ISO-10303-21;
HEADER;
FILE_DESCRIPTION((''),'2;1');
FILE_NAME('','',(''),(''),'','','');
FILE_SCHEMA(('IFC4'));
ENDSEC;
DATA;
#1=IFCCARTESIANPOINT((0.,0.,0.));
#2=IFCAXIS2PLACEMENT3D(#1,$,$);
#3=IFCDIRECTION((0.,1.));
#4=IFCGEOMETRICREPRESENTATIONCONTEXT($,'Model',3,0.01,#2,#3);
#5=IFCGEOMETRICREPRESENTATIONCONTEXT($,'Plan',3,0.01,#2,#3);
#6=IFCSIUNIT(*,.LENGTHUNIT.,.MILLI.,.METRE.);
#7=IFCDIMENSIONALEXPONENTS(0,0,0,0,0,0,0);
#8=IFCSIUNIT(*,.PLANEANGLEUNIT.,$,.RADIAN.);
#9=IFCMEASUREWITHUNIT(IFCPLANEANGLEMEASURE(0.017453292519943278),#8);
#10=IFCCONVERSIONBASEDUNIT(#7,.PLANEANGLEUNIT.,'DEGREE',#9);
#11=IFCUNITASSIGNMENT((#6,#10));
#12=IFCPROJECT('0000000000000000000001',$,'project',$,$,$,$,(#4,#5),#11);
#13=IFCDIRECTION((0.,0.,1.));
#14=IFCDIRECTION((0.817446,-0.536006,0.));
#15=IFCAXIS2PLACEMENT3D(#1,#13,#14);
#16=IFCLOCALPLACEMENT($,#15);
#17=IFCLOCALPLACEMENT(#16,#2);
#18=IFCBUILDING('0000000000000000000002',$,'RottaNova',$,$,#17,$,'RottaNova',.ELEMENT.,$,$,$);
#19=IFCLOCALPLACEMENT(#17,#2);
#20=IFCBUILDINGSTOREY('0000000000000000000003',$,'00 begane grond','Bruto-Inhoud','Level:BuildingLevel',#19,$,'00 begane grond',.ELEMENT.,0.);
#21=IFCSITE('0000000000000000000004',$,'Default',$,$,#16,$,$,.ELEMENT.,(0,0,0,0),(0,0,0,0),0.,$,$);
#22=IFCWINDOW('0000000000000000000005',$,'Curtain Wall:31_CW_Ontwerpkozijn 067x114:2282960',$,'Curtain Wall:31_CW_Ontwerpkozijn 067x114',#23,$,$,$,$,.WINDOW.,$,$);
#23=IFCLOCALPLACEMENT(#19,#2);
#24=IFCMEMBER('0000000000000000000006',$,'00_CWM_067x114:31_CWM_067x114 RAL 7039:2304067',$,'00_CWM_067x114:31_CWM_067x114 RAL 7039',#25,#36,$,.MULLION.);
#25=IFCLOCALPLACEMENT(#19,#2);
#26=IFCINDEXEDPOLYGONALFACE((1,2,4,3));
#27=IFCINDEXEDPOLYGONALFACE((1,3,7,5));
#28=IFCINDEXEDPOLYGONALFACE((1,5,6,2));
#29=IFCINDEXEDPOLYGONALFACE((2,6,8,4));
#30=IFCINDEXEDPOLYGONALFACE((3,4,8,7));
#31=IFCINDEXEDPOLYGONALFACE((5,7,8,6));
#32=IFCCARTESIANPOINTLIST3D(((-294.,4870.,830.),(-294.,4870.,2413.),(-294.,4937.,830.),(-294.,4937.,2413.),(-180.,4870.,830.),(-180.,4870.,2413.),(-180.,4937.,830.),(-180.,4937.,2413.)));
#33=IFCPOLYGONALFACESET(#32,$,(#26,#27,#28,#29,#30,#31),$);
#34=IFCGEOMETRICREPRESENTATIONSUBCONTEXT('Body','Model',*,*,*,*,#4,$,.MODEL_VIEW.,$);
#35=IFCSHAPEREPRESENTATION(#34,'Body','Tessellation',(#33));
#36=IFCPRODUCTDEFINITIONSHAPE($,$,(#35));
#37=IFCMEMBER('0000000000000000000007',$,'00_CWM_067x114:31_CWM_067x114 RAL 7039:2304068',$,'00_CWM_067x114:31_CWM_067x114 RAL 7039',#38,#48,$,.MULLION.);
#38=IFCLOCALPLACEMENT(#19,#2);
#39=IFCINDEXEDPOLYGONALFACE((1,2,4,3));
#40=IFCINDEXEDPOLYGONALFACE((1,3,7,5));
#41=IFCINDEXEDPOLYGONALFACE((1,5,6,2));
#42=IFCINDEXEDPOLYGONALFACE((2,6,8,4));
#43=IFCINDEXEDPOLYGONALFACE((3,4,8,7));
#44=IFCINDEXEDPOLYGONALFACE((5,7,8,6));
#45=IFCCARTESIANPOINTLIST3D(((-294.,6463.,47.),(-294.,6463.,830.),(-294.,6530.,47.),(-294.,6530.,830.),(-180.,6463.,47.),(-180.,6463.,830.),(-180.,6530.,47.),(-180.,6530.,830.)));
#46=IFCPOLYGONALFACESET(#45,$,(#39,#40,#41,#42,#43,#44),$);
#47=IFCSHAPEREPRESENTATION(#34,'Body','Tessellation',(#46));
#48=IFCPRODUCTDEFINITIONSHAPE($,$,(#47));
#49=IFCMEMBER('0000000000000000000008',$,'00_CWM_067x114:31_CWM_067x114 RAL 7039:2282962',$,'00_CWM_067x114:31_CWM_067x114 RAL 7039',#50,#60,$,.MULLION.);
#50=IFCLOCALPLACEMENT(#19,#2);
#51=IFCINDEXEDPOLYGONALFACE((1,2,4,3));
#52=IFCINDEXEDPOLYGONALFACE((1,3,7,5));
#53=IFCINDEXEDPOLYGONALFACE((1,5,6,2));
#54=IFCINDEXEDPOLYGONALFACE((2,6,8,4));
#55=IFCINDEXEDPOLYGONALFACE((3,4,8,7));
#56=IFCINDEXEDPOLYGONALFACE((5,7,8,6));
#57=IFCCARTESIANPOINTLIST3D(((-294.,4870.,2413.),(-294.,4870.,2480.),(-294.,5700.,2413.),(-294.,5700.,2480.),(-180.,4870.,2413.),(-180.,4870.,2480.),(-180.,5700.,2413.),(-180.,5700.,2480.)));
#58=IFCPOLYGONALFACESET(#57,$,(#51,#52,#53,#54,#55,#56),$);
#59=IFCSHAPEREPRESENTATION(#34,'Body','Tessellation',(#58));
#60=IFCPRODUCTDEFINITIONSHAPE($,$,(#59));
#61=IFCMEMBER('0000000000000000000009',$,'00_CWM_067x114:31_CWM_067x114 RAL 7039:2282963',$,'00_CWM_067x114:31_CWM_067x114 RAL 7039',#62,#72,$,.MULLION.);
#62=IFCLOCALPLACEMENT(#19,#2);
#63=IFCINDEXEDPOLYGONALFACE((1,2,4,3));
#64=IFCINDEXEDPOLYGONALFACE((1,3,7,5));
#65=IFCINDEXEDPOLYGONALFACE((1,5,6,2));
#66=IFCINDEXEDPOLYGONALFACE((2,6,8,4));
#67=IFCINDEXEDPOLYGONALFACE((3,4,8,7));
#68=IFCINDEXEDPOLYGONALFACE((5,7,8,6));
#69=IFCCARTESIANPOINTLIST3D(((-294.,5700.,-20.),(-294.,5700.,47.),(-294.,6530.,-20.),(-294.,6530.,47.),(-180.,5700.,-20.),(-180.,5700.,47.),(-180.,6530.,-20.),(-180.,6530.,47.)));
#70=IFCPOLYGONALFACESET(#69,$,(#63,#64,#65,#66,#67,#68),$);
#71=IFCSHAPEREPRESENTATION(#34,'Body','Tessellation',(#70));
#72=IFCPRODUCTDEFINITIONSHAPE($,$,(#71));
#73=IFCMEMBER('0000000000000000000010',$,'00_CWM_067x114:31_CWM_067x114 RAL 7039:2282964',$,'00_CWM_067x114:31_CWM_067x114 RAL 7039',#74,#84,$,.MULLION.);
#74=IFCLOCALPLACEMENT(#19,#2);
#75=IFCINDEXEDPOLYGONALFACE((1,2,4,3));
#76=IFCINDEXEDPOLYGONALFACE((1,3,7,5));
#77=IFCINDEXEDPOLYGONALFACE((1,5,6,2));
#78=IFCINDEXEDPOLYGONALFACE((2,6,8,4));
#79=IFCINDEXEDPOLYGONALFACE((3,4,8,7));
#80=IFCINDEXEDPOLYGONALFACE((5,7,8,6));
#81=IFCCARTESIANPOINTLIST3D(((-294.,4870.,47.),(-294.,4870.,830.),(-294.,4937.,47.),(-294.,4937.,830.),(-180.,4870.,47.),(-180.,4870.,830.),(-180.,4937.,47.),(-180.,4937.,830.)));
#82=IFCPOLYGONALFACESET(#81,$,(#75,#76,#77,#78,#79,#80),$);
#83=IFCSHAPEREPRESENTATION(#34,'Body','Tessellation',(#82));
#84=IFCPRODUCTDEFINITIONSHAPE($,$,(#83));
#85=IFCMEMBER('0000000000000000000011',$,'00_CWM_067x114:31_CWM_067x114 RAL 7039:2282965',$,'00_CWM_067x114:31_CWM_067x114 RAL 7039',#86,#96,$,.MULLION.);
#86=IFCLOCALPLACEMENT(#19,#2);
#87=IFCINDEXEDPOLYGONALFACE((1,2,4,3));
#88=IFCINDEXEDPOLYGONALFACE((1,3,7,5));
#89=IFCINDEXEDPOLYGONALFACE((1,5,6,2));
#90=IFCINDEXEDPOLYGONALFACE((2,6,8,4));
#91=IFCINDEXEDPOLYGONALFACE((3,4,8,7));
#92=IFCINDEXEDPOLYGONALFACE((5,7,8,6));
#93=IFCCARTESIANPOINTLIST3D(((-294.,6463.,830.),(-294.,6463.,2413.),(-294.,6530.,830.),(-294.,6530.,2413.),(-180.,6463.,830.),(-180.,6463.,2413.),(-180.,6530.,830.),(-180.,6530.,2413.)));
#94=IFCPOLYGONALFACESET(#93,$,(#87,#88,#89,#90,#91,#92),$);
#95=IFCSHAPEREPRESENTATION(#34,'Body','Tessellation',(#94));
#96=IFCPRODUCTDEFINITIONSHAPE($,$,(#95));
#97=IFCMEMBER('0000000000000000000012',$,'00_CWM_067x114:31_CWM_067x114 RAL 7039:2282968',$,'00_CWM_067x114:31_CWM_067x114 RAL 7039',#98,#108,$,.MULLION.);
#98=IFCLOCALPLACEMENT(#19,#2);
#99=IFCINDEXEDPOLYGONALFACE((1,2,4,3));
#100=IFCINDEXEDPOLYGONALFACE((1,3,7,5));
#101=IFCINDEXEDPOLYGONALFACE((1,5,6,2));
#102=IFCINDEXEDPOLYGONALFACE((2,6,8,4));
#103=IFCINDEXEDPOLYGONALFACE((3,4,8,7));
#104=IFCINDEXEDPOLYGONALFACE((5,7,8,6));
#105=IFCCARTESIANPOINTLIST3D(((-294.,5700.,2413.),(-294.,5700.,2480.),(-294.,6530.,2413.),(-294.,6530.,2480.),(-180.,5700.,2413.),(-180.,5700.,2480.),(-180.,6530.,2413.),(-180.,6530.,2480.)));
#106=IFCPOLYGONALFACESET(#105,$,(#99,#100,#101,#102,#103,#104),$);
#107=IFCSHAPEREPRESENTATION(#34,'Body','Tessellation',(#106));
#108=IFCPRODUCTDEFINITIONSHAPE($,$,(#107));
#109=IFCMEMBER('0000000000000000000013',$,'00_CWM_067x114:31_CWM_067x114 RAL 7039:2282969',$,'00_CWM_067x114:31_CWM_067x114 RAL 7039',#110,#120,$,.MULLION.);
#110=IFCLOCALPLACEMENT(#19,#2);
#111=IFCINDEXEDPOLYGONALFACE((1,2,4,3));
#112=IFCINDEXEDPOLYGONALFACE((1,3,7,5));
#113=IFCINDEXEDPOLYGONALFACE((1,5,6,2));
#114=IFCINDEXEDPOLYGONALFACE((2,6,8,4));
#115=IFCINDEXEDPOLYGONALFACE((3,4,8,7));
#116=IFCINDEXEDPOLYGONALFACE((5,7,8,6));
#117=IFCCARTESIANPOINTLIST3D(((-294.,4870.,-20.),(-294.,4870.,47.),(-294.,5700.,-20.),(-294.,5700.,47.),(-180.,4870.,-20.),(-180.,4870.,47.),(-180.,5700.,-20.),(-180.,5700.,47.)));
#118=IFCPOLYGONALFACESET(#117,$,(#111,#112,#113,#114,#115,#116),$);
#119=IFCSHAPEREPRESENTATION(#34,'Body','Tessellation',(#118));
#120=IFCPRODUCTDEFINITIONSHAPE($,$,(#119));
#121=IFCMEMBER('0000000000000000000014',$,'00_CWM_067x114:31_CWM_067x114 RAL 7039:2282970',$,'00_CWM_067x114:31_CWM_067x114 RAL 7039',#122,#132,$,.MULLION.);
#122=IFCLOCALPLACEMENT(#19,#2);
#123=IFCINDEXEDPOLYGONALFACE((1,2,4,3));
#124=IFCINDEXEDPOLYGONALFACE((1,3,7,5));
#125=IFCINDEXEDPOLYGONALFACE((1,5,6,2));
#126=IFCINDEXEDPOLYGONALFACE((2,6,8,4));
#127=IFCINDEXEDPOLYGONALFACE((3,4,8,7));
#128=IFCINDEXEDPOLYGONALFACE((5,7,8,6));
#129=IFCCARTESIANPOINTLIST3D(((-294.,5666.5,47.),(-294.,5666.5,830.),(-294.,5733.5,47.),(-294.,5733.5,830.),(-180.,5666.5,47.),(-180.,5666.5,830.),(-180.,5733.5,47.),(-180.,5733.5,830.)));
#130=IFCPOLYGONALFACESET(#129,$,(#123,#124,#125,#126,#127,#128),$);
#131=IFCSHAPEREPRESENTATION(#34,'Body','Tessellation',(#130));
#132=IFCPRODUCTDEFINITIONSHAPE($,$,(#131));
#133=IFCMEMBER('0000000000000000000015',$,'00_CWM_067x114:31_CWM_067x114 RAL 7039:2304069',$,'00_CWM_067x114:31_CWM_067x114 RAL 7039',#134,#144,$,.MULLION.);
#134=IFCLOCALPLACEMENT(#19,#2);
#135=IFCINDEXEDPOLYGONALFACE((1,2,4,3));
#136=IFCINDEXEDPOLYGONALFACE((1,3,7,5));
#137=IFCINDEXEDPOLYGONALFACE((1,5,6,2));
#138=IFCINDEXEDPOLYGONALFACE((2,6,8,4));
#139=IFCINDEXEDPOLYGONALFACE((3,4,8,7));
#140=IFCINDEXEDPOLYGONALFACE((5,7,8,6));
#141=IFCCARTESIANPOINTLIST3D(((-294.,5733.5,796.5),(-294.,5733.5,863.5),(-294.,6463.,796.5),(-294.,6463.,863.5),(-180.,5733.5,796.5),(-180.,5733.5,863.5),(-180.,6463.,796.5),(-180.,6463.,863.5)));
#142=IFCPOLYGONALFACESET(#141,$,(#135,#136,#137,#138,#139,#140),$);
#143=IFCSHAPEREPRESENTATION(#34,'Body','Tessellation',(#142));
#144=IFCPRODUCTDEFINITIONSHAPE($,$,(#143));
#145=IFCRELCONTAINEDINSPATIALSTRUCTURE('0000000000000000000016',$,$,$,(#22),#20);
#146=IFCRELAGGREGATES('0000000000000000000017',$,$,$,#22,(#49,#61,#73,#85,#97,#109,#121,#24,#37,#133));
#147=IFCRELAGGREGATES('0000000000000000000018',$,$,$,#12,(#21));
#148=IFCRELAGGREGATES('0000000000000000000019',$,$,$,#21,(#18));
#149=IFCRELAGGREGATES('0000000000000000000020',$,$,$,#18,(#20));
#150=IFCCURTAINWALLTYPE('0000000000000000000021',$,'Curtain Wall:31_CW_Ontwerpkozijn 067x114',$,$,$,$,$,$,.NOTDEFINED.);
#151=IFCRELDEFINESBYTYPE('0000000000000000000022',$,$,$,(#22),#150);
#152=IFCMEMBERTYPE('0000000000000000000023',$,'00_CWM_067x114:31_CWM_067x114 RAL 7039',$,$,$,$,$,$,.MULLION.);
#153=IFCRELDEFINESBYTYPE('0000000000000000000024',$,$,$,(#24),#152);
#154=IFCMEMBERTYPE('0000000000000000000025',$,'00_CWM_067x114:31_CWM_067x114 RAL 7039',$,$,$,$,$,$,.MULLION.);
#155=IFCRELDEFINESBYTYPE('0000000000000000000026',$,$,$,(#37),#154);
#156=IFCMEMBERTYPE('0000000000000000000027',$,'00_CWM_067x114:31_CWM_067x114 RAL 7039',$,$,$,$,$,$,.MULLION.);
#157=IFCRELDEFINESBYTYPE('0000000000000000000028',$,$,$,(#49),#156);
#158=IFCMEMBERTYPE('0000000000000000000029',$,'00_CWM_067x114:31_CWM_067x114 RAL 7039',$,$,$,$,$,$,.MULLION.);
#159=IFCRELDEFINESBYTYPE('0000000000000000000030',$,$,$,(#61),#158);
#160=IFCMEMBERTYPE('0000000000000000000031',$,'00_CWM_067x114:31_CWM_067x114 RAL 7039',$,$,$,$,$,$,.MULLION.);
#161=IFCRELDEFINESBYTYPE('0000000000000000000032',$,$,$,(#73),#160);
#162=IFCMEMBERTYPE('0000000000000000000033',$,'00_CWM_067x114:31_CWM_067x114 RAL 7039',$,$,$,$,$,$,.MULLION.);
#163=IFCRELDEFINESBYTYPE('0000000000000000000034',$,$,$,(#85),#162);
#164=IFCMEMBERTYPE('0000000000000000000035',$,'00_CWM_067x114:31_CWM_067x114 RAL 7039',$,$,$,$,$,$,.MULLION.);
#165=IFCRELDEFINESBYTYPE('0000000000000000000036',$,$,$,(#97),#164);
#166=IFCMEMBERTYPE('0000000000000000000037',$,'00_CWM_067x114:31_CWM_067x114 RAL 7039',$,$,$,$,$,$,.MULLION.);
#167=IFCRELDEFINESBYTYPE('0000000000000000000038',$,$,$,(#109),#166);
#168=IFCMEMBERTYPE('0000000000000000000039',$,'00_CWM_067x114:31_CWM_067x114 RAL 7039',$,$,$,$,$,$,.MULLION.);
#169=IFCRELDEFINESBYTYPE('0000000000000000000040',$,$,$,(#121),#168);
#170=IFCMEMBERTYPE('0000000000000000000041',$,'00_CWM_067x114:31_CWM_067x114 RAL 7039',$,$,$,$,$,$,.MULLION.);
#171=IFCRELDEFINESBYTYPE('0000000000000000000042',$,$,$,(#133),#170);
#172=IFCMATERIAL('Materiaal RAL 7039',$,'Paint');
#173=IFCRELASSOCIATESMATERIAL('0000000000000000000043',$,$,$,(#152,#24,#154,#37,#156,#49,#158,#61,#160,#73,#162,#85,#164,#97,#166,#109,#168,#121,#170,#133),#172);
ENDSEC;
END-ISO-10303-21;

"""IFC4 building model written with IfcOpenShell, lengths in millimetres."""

from ifc_helpers import new_model, entity, si_unit, converted_unit, direction, frame, origin, place, context, subcontext, project, spatial, indexed_curve, outline, extrude, source, transform, mapped, material, type_object, type_shapes, element, aggregate, save


model = new_model("IFC4")

# Units and contexts
model_context = context("Model", 3, precision=0.01, world=origin(), true_north=direction((0.0, 1.0)))
plan_context = context("Plan", 3, precision=0.01, world=origin(), true_north=direction((0.0, 1.0)))
body_context = subcontext(model_context, "Body", "Model", "MODEL_VIEW")
ifc_project = project(units=[si_unit("LENGTHUNIT", "METRE", prefix="MILLI"), converted_unit("PLANEANGLEUNIT", "DEGREE", entity("IfcPlaneAngleMeasure", 0.017453292519943278), si_unit("PLANEANGLEUNIT", "RADIAN"), dimensions=[0, 0, 0, 0, 0, 0, 0])], contexts=[model_context, plan_context])

# Site, building, storey
site_placement = place(None, frame((0.0, 0.0, 0.0), z_axis=(0.0, 0.0, 1.0), x_axis=(0.817446, -0.536006, 0.0)))
site = spatial("IfcSite", under=ifc_project, at=site_placement, Name="Default", CompositionType="ELEMENT", RefLatitude=(0, 0, 0, 0), RefLongitude=(0, 0, 0, 0), RefElevation=0.0)
building_placement = place(site_placement, origin())
building = spatial("IfcBuilding", under=site, at=building_placement, Name="RottaNova", LongName="RottaNova", CompositionType="ELEMENT")
storey_placement = place(building_placement, origin())
storey = spatial("IfcBuildingStorey", under=building, at=storey_placement, Name="00 begane grond", Description="Bruto-Inhoud", ObjectType="Level:BuildingLevel", LongName="00 begane grond", CompositionType="ELEMENT", Elevation=0.0)

# Window, members
curtain_wall_type = type_object("IfcCurtainWallType", Name="Curtain Wall:31_CW_Ontwerpkozijn 067x114", PredefinedType="NOTDEFINED")
window_placement = place(storey_placement, origin())
window = element("IfcWindow", 1, at=window_placement, inside=storey, type_object=curtain_wall_type, Name="Curtain Wall:31_CW_Ontwerpkozijn 067x114:2282960", ObjectType="Curtain Wall:31_CW_Ontwerpkozijn 067x114", PredefinedType="WINDOW")
ifc_material_1 = material(Name="Materiaal RAL 7039", Category="Paint")
member_type_1 = type_object("IfcMemberType", Name="00_CWM_067x114:31_CWM_067x114 RAL 7039", PredefinedType="MULLION", material=ifc_material_1)
shared_shape_1 = source(origin(), body_context, "Body", "SweptSolid", [
    extrude(outline(indexed_curve([(-33.5, -57.0), (33.5, -57.0), (33.5, 57.0), (-33.5, 57.0), (-33.5, -57.0)], self_intersect=False)), frame((-33.5, 57.0, -1583.0), z_axis=(0.0, 0.0, 1.0), x_axis=(-1.0, 0.0, 0.0)), (0.0, 0.0, 1.0), 1583.0),
])
type_shapes(member_type_1, [shared_shape_1])
member_1_placement = place(window_placement, frame((-180.0, 4870.0, 830.0), z_axis=(0.0, 0.0, -1.0), x_axis=(0.0, -1.0, 0.0)))
member_1 = element("IfcMember", 2, at=member_1_placement, type_object=member_type_1, material=ifc_material_1, Name="00_CWM_067x114:31_CWM_067x114 RAL 7039:2304067", ObjectType="00_CWM_067x114:31_CWM_067x114 RAL 7039", PredefinedType="MULLION", context=body_context, shape_type="MappedRepresentation", body=[
    mapped(shared_shape_1, transform((0.0, 0.0, 0.0), scale=1.0)),
])
member_type_2 = type_object("IfcMemberType", Name="00_CWM_067x114:31_CWM_067x114 RAL 7039", PredefinedType="MULLION", material=ifc_material_1)
shared_shape_2 = source(origin(), body_context, "Body", "SweptSolid", [
    extrude(outline(indexed_curve([(-33.5, -57.0), (33.5, -57.0), (33.5, 57.0), (-33.5, 57.0), (-33.5, -57.0)], self_intersect=False)), frame((-33.5, 57.0, -783.0), z_axis=(0.0, 0.0, 1.0), x_axis=(-1.0, 0.0, 0.0)), (0.0, 0.0, 1.0), 783.0),
])
type_shapes(member_type_2, [shared_shape_2])
member_2_placement = place(window_placement, frame((-180.0, 6530.0, 830.0), z_axis=(0.0, 0.0, 1.0), x_axis=(0.0, 1.0, 0.0)))
member_2 = element("IfcMember", 3, at=member_2_placement, type_object=member_type_2, material=ifc_material_1, Name="00_CWM_067x114:31_CWM_067x114 RAL 7039:2304068", ObjectType="00_CWM_067x114:31_CWM_067x114 RAL 7039", PredefinedType="MULLION", context=body_context, shape_type="MappedRepresentation", body=[
    mapped(shared_shape_2, transform((0.0, 0.0, 0.0), scale=1.0)),
])
member_type_3 = type_object("IfcMemberType", Name="00_CWM_067x114:31_CWM_067x114 RAL 7039", PredefinedType="MULLION", material=ifc_material_1)
shared_shape_3 = source(origin(), body_context, "Body", "SweptSolid", [
    extrude(outline(indexed_curve([(-33.5, -57.0), (33.5, -57.0), (33.5, 57.0), (-33.5, 57.0), (-33.5, -57.0)], self_intersect=False)), frame((-33.5, 57.0, -830.0), z_axis=(0.0, 0.0, 1.0), x_axis=(-1.0, 0.0, 0.0)), (0.0, 0.0, 1.0), 830.0),
])
type_shapes(member_type_3, [shared_shape_3])
member_3_placement = place(window_placement, frame((-180.0, 4870.0, 2480.0), z_axis=(0.0, -1.0, 0.0), x_axis=(0.0, 0.0, 1.0)))
member_3 = element("IfcMember", 4, at=member_3_placement, type_object=member_type_3, material=ifc_material_1, Name="00_CWM_067x114:31_CWM_067x114 RAL 7039:2282962", ObjectType="00_CWM_067x114:31_CWM_067x114 RAL 7039", PredefinedType="MULLION", context=body_context, shape_type="MappedRepresentation", body=[
    mapped(shared_shape_3, transform((0.0, 0.0, 0.0), scale=1.0)),
])
member_type_4 = type_object("IfcMemberType", Name="00_CWM_067x114:31_CWM_067x114 RAL 7039", PredefinedType="MULLION", material=ifc_material_1)
shared_shape_4 = source(origin(), body_context, "Body", "SweptSolid", [
    extrude(outline(indexed_curve([(-33.5, -57.0), (33.5, -57.0), (33.5, 57.0), (-33.5, 57.0), (-33.5, -57.0)], self_intersect=False)), frame((-33.5, 57.0, -830.0), z_axis=(0.0, 0.0, 1.0), x_axis=(-1.0, 0.0, 0.0)), (0.0, 0.0, 1.0), 830.0),
])
type_shapes(member_type_4, [shared_shape_4])
member_4_placement = place(window_placement, frame((-180.0, 6530.0, -20.0), z_axis=(0.0, 1.0, 0.0), x_axis=(0.0, 0.0, -1.0)))
member_4 = element("IfcMember", 5, at=member_4_placement, type_object=member_type_4, material=ifc_material_1, Name="00_CWM_067x114:31_CWM_067x114 RAL 7039:2282963", ObjectType="00_CWM_067x114:31_CWM_067x114 RAL 7039", PredefinedType="MULLION", context=body_context, shape_type="MappedRepresentation", body=[
    mapped(shared_shape_4, transform((0.0, 0.0, 0.0), scale=1.0)),
])
member_type_5 = type_object("IfcMemberType", Name="00_CWM_067x114:31_CWM_067x114 RAL 7039", PredefinedType="MULLION", material=ifc_material_1)
shared_shape_5 = source(origin(), body_context, "Body", "SweptSolid", [
    extrude(outline(indexed_curve([(-33.5, -57.0), (33.5, -57.0), (33.5, 57.0), (-33.5, 57.0), (-33.5, -57.0)], self_intersect=False)), frame((-33.5, 57.0, -783.0), z_axis=(0.0, 0.0, 1.0), x_axis=(-1.0, 0.0, 0.0)), (0.0, 0.0, 1.0), 783.0),
])
type_shapes(member_type_5, [shared_shape_5])
member_5_placement = place(window_placement, frame((-180.0, 4870.0, 47.0), z_axis=(0.0, 0.0, -1.0), x_axis=(0.0, -1.0, 0.0)))
member_5 = element("IfcMember", 6, at=member_5_placement, type_object=member_type_5, material=ifc_material_1, Name="00_CWM_067x114:31_CWM_067x114 RAL 7039:2282964", ObjectType="00_CWM_067x114:31_CWM_067x114 RAL 7039", PredefinedType="MULLION", context=body_context, shape_type="MappedRepresentation", body=[
    mapped(shared_shape_5, transform((0.0, 0.0, 0.0), scale=1.0)),
])
member_type_6 = type_object("IfcMemberType", Name="00_CWM_067x114:31_CWM_067x114 RAL 7039", PredefinedType="MULLION", material=ifc_material_1)
shared_shape_6 = source(origin(), body_context, "Body", "SweptSolid", [
    extrude(outline(indexed_curve([(-33.5, -57.0), (33.5, -57.0), (33.5, 57.0), (-33.5, 57.0), (-33.5, -57.0)], self_intersect=False)), frame((-33.5, 57.0, -1583.0), z_axis=(0.0, 0.0, 1.0), x_axis=(-1.0, 0.0, 0.0)), (0.0, 0.0, 1.0), 1583.0),
])
type_shapes(member_type_6, [shared_shape_6])
member_6_placement = place(window_placement, frame((-180.0, 6530.0, 2413.0), z_axis=(0.0, 0.0, 1.0), x_axis=(0.0, 1.0, 0.0)))
member_6 = element("IfcMember", 7, at=member_6_placement, type_object=member_type_6, material=ifc_material_1, Name="00_CWM_067x114:31_CWM_067x114 RAL 7039:2282965", ObjectType="00_CWM_067x114:31_CWM_067x114 RAL 7039", PredefinedType="MULLION", context=body_context, shape_type="MappedRepresentation", body=[
    mapped(shared_shape_6, transform((0.0, 0.0, 0.0), scale=1.0)),
])
member_type_7 = type_object("IfcMemberType", Name="00_CWM_067x114:31_CWM_067x114 RAL 7039", PredefinedType="MULLION", material=ifc_material_1)
shared_shape_7 = source(origin(), body_context, "Body", "SweptSolid", [
    extrude(outline(indexed_curve([(-33.5, -57.0), (33.5, -57.0), (33.5, 57.0), (-33.5, 57.0), (-33.5, -57.0)], self_intersect=False)), frame((-33.5, 57.0, -830.0), z_axis=(0.0, 0.0, 1.0), x_axis=(-1.0, 0.0, 0.0)), (0.0, 0.0, 1.0), 830.0),
])
type_shapes(member_type_7, [shared_shape_7])
member_7_placement = place(window_placement, frame((-180.0, 5700.0, 2480.0), z_axis=(0.0, -1.0, 0.0), x_axis=(0.0, 0.0, 1.0)))
member_7 = element("IfcMember", 8, at=member_7_placement, type_object=member_type_7, material=ifc_material_1, Name="00_CWM_067x114:31_CWM_067x114 RAL 7039:2282968", ObjectType="00_CWM_067x114:31_CWM_067x114 RAL 7039", PredefinedType="MULLION", context=body_context, shape_type="MappedRepresentation", body=[
    mapped(shared_shape_7, transform((0.0, 0.0, 0.0), scale=1.0)),
])
member_type_8 = type_object("IfcMemberType", Name="00_CWM_067x114:31_CWM_067x114 RAL 7039", PredefinedType="MULLION", material=ifc_material_1)
shared_shape_8 = source(origin(), body_context, "Body", "SweptSolid", [
    extrude(outline(indexed_curve([(-33.5, -57.0), (33.5, -57.0), (33.5, 57.0), (-33.5, 57.0), (-33.5, -57.0)], self_intersect=False)), frame((-33.5, 57.0, -830.0), z_axis=(0.0, 0.0, 1.0), x_axis=(-1.0, 0.0, 0.0)), (0.0, 0.0, 1.0), 830.0),
])
type_shapes(member_type_8, [shared_shape_8])
member_8_placement = place(window_placement, frame((-180.0, 5700.0, -20.0), z_axis=(0.0, 1.0, 0.0), x_axis=(0.0, 0.0, -1.0)))
member_8 = element("IfcMember", 9, at=member_8_placement, type_object=member_type_8, material=ifc_material_1, Name="00_CWM_067x114:31_CWM_067x114 RAL 7039:2282969", ObjectType="00_CWM_067x114:31_CWM_067x114 RAL 7039", PredefinedType="MULLION", context=body_context, shape_type="MappedRepresentation", body=[
    mapped(shared_shape_8, transform((0.0, 0.0, 0.0), scale=1.0)),
])
member_type_9 = type_object("IfcMemberType", Name="00_CWM_067x114:31_CWM_067x114 RAL 7039", PredefinedType="MULLION", material=ifc_material_1)
shared_shape_9 = source(origin(), body_context, "Body", "SweptSolid", [
    extrude(outline(indexed_curve([(-33.5, -57.0), (33.5, -57.0), (33.5, 57.0), (-33.5, 57.0), (-33.5, -57.0)], self_intersect=False)), frame((0.0, 57.0, -783.0), z_axis=(0.0, 0.0, 1.0), x_axis=(-1.0, 0.0, 0.0)), (0.0, 0.0, 1.0), 783.0),
])
type_shapes(member_type_9, [shared_shape_9])
member_9_placement = place(window_placement, frame((-180.0, 5700.0, 47.0), z_axis=(0.0, 0.0, -1.0), x_axis=(0.0, -1.0, 0.0)))
member_9 = element("IfcMember", 10, at=member_9_placement, type_object=member_type_9, material=ifc_material_1, Name="00_CWM_067x114:31_CWM_067x114 RAL 7039:2282970", ObjectType="00_CWM_067x114:31_CWM_067x114 RAL 7039", PredefinedType="MULLION", context=body_context, shape_type="MappedRepresentation", body=[
    mapped(shared_shape_9, transform((0.0, 0.0, 0.0), scale=1.0)),
])
member_type_10 = type_object("IfcMemberType", Name="00_CWM_067x114:31_CWM_067x114 RAL 7039", PredefinedType="MULLION", material=ifc_material_1)
shared_shape_10 = source(origin(), body_context, "Body", "SweptSolid", [
    extrude(outline(indexed_curve([(-33.5, -57.0), (33.5, -57.0), (33.5, 57.0), (-33.5, 57.0), (-33.5, -57.0)], self_intersect=False)), frame((0.0, 57.0, -729.5), z_axis=(0.0, 0.0, 1.0), x_axis=(-1.0, 0.0, 0.0)), (0.0, 0.0, 1.0), 729.5),
])
type_shapes(member_type_10, [shared_shape_10])
member_10_placement = place(window_placement, frame((-180.0, 5733.5, 830.0), z_axis=(0.0, -1.0, 0.0), x_axis=(0.0, 0.0, 1.0)))
member_10 = element("IfcMember", 11, at=member_10_placement, type_object=member_type_10, material=ifc_material_1, Name="00_CWM_067x114:31_CWM_067x114 RAL 7039:2304069", ObjectType="00_CWM_067x114:31_CWM_067x114 RAL 7039", PredefinedType="MULLION", context=body_context, shape_type="MappedRepresentation", body=[
    mapped(shared_shape_10, transform((0.0, 0.0, 0.0), scale=1.0)),
])
aggregate(window, [member_3, member_4, member_5, member_6, member_7, member_8, member_9, member_1, member_2, member_10])

save(model, "model.ifc")
